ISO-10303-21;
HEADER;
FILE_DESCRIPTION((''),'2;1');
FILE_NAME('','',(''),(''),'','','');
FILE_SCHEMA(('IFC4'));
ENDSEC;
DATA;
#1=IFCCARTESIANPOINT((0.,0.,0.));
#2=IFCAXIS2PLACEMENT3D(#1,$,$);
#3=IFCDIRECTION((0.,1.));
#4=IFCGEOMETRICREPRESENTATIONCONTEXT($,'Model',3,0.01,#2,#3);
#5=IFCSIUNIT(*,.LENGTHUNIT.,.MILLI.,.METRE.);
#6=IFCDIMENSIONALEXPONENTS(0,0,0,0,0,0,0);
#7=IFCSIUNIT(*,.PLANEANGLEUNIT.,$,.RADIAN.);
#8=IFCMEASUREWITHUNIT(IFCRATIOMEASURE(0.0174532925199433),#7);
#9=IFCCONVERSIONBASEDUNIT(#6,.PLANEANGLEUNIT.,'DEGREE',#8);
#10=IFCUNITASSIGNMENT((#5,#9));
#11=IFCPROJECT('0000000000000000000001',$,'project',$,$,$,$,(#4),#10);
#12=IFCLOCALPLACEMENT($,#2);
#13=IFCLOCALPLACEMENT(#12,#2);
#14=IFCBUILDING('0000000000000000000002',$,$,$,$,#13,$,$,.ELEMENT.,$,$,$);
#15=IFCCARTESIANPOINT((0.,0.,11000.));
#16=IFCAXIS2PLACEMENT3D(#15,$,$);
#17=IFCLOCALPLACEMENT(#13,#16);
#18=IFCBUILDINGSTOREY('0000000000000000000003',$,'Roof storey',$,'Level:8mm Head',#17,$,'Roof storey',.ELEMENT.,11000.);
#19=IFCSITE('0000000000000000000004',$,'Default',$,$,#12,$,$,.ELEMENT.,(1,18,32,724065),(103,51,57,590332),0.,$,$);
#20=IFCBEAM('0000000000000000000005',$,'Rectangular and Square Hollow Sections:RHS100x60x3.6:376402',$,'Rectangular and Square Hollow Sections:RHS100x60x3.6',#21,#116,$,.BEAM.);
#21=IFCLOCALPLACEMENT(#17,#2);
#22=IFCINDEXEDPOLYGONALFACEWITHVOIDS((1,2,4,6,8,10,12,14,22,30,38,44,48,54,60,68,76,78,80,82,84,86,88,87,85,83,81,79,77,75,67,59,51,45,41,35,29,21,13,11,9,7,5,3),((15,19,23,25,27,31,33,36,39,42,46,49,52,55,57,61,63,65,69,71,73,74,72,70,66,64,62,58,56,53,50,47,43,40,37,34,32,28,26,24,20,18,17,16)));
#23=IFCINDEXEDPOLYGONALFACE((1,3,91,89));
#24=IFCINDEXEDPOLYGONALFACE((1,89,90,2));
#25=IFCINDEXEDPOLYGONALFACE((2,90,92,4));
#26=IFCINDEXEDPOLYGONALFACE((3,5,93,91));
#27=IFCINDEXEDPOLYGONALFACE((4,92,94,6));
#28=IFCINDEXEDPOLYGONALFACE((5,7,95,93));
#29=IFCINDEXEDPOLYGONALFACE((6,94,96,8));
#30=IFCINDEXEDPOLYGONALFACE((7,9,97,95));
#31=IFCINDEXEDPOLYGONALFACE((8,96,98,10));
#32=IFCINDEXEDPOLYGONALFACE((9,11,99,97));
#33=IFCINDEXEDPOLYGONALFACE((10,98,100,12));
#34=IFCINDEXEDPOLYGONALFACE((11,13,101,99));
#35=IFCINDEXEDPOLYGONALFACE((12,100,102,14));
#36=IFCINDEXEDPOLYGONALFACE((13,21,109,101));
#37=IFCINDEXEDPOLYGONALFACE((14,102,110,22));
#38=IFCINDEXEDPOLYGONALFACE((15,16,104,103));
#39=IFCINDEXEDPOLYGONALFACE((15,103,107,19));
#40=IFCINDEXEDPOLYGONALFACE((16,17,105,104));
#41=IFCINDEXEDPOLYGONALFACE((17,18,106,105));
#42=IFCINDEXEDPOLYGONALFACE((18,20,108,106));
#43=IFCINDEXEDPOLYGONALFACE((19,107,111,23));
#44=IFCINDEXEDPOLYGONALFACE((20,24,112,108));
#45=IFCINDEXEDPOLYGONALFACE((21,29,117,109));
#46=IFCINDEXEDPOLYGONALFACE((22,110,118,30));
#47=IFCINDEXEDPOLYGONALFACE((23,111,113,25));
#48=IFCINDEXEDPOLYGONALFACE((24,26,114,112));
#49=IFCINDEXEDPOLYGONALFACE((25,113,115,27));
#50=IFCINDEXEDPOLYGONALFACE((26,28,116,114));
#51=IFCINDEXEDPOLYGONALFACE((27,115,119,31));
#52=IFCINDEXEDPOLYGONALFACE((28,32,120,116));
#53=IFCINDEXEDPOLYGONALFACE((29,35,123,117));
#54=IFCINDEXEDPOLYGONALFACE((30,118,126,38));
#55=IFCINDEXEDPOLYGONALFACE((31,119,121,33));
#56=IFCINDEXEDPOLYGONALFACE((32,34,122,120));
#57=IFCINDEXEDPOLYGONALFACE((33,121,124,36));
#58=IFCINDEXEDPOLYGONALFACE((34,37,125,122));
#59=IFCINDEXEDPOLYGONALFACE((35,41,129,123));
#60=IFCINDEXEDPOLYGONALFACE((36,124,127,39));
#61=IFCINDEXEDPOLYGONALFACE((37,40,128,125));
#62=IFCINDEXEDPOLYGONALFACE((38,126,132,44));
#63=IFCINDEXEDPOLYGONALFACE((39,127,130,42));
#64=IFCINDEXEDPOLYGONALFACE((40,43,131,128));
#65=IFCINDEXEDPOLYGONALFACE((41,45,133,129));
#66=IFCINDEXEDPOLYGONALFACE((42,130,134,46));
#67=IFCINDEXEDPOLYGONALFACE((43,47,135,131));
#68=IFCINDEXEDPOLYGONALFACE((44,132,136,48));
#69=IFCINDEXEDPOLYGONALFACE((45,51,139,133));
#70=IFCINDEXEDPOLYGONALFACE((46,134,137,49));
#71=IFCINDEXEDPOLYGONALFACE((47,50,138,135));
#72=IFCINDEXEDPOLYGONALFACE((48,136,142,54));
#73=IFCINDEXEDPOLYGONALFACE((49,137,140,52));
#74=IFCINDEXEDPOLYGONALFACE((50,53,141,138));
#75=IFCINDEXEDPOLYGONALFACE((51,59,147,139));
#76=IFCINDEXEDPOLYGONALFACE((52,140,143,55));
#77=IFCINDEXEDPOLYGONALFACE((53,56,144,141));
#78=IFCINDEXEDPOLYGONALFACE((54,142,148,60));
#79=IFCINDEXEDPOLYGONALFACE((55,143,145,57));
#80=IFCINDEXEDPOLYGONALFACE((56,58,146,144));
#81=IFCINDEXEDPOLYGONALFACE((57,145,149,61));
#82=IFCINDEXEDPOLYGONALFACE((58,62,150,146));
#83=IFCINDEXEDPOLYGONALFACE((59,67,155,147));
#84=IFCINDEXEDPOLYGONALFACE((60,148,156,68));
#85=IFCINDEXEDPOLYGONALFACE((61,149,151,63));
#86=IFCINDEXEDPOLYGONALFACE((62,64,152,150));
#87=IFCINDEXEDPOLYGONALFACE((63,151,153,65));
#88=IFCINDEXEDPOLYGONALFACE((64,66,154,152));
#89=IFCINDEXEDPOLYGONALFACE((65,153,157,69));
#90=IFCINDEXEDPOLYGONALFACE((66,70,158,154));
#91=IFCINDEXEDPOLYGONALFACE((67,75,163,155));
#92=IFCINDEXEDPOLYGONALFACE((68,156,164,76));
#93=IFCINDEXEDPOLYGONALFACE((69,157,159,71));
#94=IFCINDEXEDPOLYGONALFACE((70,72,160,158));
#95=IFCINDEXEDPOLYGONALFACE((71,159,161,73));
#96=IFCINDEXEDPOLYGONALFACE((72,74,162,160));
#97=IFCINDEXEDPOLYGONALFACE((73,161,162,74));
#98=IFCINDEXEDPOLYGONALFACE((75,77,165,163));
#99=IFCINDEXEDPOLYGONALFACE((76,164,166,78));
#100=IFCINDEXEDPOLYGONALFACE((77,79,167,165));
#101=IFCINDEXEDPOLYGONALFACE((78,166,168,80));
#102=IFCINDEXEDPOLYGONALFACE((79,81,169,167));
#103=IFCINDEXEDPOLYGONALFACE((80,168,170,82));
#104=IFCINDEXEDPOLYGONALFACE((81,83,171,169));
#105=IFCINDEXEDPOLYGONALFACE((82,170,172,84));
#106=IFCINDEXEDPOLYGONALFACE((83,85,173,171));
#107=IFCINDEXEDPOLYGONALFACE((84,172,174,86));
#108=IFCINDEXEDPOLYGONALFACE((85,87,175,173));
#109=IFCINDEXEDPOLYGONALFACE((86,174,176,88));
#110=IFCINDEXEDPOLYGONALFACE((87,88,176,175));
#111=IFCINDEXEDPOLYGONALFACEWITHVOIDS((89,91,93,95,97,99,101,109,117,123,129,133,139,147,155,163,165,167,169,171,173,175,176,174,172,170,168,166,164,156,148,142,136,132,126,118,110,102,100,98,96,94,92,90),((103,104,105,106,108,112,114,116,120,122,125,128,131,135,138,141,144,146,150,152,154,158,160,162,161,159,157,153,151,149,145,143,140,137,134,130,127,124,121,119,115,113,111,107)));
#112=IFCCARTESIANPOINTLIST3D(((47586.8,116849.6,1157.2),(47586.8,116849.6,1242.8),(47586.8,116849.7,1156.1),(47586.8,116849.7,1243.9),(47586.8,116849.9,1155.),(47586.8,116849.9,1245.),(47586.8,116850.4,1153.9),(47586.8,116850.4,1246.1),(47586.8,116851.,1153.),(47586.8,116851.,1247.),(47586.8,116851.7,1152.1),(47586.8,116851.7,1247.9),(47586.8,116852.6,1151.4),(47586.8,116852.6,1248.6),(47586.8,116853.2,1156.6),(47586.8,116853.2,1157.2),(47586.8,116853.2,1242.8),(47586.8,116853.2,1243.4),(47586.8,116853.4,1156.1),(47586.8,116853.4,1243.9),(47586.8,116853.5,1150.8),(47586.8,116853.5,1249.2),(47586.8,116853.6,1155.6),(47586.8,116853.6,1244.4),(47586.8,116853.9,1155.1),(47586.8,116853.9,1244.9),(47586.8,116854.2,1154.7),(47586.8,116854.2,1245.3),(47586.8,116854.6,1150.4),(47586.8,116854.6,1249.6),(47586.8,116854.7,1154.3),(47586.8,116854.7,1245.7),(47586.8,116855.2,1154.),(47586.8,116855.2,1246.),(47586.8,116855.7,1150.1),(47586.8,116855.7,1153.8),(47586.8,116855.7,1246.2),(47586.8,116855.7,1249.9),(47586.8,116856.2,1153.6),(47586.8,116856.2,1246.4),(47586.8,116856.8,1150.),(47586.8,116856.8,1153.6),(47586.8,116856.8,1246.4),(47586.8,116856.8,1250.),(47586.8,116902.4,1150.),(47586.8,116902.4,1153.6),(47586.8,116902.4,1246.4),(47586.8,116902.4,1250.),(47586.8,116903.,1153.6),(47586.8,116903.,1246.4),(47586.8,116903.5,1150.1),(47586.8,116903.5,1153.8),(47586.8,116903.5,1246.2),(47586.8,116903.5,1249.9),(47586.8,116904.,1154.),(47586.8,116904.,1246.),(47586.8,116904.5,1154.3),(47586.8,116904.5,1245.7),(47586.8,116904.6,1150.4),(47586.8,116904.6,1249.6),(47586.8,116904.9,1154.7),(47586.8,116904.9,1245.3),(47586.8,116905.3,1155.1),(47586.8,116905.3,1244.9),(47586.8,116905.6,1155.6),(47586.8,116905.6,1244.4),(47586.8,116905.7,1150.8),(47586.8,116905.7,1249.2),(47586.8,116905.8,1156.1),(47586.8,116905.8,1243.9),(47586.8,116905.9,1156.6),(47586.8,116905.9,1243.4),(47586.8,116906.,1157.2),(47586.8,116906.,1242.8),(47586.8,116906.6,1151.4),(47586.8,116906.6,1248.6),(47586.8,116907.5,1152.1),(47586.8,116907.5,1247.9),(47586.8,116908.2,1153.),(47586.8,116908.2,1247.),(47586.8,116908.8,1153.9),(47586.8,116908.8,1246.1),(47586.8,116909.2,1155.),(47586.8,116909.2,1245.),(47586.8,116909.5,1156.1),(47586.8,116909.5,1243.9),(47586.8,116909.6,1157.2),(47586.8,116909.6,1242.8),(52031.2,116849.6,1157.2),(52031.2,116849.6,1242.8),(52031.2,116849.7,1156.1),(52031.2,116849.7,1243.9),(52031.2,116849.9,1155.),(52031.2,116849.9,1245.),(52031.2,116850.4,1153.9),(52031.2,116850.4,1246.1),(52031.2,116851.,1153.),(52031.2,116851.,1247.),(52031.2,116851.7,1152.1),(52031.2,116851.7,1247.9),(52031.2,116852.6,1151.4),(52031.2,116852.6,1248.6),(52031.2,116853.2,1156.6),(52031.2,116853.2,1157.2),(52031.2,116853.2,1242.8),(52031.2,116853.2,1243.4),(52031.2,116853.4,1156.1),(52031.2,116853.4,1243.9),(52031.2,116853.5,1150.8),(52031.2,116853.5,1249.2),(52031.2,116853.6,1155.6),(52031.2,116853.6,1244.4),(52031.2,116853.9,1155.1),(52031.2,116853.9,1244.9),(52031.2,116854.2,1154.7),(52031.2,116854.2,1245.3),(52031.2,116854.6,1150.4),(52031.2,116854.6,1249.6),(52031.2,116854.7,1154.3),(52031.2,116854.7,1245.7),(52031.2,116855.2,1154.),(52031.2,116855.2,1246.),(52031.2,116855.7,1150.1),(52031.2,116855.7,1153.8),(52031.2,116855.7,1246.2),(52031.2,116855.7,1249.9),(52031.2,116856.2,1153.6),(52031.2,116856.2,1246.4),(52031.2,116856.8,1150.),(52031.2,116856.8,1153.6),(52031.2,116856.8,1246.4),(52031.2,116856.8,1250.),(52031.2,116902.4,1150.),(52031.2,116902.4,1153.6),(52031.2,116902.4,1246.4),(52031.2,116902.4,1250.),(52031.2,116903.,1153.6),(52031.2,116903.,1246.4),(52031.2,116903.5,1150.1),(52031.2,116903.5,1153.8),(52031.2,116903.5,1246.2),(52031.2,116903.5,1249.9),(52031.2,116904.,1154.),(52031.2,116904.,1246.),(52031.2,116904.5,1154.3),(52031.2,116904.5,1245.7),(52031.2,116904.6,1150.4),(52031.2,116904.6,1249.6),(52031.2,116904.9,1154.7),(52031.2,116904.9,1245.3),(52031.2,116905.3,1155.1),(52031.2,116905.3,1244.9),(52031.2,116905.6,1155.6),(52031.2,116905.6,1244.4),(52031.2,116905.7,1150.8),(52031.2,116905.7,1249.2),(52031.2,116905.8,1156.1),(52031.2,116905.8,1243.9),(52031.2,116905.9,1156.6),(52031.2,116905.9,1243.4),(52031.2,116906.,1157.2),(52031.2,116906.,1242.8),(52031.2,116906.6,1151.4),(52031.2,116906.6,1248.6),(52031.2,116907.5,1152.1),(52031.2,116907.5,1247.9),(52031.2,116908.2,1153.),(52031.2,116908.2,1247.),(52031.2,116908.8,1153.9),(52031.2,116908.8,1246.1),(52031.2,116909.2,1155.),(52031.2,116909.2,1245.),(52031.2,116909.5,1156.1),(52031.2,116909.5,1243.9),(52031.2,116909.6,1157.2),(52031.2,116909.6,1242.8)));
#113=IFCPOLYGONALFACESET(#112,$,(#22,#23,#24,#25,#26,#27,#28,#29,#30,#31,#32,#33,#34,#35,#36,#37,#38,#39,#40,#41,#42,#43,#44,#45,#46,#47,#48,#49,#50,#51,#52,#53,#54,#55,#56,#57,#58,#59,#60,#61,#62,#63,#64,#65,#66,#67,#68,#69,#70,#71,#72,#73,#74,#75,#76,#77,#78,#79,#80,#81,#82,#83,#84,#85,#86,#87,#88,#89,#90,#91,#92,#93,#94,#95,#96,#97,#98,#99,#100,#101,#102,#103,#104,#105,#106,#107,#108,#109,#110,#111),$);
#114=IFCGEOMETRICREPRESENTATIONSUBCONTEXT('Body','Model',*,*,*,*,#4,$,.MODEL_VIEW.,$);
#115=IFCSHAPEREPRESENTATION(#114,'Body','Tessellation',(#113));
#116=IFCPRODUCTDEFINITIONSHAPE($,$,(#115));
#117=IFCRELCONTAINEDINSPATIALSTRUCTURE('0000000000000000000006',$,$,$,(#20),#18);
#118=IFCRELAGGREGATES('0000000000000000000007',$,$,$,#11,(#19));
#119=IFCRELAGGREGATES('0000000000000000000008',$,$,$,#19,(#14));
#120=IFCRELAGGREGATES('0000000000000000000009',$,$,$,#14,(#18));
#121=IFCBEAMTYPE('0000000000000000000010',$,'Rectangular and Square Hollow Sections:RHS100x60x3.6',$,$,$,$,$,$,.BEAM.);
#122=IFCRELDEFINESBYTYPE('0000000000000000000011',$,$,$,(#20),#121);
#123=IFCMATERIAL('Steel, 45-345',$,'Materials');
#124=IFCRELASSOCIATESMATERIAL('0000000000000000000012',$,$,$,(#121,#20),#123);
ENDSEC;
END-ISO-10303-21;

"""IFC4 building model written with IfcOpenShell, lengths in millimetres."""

from ifc_helpers import new_model, entity, si_unit, converted_unit, direction, frame, origin, place, context, subcontext, project, spatial, indexed_curve, outline, extrude, source, transform, mapped, material, type_object, type_shapes, element, save


model = new_model("IFC4")

# Units and contexts
model_context = context("Model", 3, precision=0.01, world=origin(), true_north=direction((0.0, 1.0)))
body_context = subcontext(model_context, "Body", "Model", "MODEL_VIEW")
ifc_project = project(units=[si_unit("LENGTHUNIT", "METRE", prefix="MILLI"), converted_unit("PLANEANGLEUNIT", "DEGREE", entity("IfcRatioMeasure", 0.0174532925199433), si_unit("PLANEANGLEUNIT", "RADIAN"), dimensions=[0, 0, 0, 0, 0, 0, 0])], contexts=[model_context])

# Site, building, storey
site_placement = place(None, origin())
site = spatial("IfcSite", under=ifc_project, at=site_placement, Name="Default", CompositionType="ELEMENT", RefLatitude=(1, 18, 32, 724065), RefLongitude=(103, 51, 57, 590332), RefElevation=0.0)
building_placement = place(site_placement, origin())
building = spatial("IfcBuilding", under=site, at=building_placement, CompositionType="ELEMENT")
storey_placement = place(building_placement, frame((0.0, 0.0, 11000.0)))
storey = spatial("IfcBuildingStorey", under=building, at=storey_placement, Name="Roof storey", ObjectType="Level:8mm Head", LongName="Roof storey", CompositionType="ELEMENT", Elevation=11000.0)

# Shared definitions
ifc_material = material(Name="Steel, 45-345", Category="Materials")

# Beam
beam_type_1 = type_object("IfcBeamType", Name="Rectangular and Square Hollow Sections:RHS100x60x3.6", PredefinedType="BEAM", material=ifc_material)
shared_shape_1 = source(origin(), body_context, "Body", "SweptSolid", [
    extrude(outline(indexed_curve([(-30.0, -42.8), (-29.9, -43.9), (-29.6, -45.0), (-29.2, -46.1), (-28.6, -47.0), (-27.9, -47.9), (-27.0, -48.6), (-26.1, -49.2), (-25.0, -49.6), (-23.9, -49.9), (-22.8, -50.0), (22.8, -50.0), (23.9, -49.9), (25.0, -49.6), (26.1, -49.2), (27.0, -48.6), (27.9, -47.9), (28.6, -47.0), (29.2, -46.1), (29.6, -45.0), (29.9, -43.9), (30.0, -42.8), (30.0, 42.8), (29.9, 43.9), (29.6, 45.0), (29.2, 46.1), (28.6, 47.0), (27.9, 47.9), (27.0, 48.6), (26.1, 49.2), (25.0, 49.6), (23.9, 49.9), (22.8, 50.0), (-22.8, 50.0), (-23.9, 49.9), (-25.0, 49.6), (-26.1, 49.2), (-27.0, 48.6), (-27.9, 47.9), (-28.6, 47.0), (-29.2, 46.1), (-29.6, 45.0), (-29.9, 43.9), (-30.0, 42.8), (-30.0, -42.8)], self_intersect=False), holes=[indexed_curve([(22.8, -46.4), (-22.8, -46.4), (-23.4, -46.4), (-23.9, -46.2), (-24.4, -46.0), (-24.9, -45.7), (-25.3, -45.3), (-25.7, -44.9), (-26.0, -44.4), (-26.2, -43.9), (-26.4, -43.4), (-26.4, -42.8), (-26.4, 42.8), (-26.4, 43.4), (-26.2, 43.9), (-26.0, 44.4), (-25.7, 44.9), (-25.3, 45.3), (-24.9, 45.7), (-24.4, 46.0), (-23.9, 46.2), (-23.4, 46.4), (-22.8, 46.4), (22.8, 46.4), (23.4, 46.4), (23.9, 46.2), (24.4, 46.0), (24.9, 45.7), (25.3, 45.3), (25.7, 44.9), (26.0, 44.4), (26.2, 43.9), (26.4, 43.4), (26.4, 42.8), (26.4, -42.8), (26.4, -43.4), (26.2, -43.9), (26.0, -44.4), (25.7, -44.9), (25.3, -45.3), (24.9, -45.7), (24.4, -46.0), (23.9, -46.2), (23.4, -46.4), (22.8, -46.4)], self_intersect=False)]), frame((-2191.8, 0.0, 0.0), z_axis=(1.0, 0.0, 0.0), x_axis=(0.0, -1.0, 0.0)), (0.0, 0.0, 1.0), 4444.3),
])
type_shapes(beam_type_1, [shared_shape_1])
beam_1_placement = place(storey_placement, frame((49839.3, 116879.6, 1200.0), z_axis=(0.0, 0.0, 1.0), x_axis=(-1.0, 0.0, 0.0)))
element("IfcBeam", 1, at=beam_1_placement, inside=storey, type_object=beam_type_1, material=ifc_material, Name="Rectangular and Square Hollow Sections:RHS100x60x3.6:376402", ObjectType="Rectangular and Square Hollow Sections:RHS100x60x3.6", PredefinedType="BEAM", context=body_context, shape_type="MappedRepresentation", body=[
    mapped(shared_shape_1, transform((0.0, 0.0, 0.0), scale=1.0)),
])

save(model, "model.ifc")
